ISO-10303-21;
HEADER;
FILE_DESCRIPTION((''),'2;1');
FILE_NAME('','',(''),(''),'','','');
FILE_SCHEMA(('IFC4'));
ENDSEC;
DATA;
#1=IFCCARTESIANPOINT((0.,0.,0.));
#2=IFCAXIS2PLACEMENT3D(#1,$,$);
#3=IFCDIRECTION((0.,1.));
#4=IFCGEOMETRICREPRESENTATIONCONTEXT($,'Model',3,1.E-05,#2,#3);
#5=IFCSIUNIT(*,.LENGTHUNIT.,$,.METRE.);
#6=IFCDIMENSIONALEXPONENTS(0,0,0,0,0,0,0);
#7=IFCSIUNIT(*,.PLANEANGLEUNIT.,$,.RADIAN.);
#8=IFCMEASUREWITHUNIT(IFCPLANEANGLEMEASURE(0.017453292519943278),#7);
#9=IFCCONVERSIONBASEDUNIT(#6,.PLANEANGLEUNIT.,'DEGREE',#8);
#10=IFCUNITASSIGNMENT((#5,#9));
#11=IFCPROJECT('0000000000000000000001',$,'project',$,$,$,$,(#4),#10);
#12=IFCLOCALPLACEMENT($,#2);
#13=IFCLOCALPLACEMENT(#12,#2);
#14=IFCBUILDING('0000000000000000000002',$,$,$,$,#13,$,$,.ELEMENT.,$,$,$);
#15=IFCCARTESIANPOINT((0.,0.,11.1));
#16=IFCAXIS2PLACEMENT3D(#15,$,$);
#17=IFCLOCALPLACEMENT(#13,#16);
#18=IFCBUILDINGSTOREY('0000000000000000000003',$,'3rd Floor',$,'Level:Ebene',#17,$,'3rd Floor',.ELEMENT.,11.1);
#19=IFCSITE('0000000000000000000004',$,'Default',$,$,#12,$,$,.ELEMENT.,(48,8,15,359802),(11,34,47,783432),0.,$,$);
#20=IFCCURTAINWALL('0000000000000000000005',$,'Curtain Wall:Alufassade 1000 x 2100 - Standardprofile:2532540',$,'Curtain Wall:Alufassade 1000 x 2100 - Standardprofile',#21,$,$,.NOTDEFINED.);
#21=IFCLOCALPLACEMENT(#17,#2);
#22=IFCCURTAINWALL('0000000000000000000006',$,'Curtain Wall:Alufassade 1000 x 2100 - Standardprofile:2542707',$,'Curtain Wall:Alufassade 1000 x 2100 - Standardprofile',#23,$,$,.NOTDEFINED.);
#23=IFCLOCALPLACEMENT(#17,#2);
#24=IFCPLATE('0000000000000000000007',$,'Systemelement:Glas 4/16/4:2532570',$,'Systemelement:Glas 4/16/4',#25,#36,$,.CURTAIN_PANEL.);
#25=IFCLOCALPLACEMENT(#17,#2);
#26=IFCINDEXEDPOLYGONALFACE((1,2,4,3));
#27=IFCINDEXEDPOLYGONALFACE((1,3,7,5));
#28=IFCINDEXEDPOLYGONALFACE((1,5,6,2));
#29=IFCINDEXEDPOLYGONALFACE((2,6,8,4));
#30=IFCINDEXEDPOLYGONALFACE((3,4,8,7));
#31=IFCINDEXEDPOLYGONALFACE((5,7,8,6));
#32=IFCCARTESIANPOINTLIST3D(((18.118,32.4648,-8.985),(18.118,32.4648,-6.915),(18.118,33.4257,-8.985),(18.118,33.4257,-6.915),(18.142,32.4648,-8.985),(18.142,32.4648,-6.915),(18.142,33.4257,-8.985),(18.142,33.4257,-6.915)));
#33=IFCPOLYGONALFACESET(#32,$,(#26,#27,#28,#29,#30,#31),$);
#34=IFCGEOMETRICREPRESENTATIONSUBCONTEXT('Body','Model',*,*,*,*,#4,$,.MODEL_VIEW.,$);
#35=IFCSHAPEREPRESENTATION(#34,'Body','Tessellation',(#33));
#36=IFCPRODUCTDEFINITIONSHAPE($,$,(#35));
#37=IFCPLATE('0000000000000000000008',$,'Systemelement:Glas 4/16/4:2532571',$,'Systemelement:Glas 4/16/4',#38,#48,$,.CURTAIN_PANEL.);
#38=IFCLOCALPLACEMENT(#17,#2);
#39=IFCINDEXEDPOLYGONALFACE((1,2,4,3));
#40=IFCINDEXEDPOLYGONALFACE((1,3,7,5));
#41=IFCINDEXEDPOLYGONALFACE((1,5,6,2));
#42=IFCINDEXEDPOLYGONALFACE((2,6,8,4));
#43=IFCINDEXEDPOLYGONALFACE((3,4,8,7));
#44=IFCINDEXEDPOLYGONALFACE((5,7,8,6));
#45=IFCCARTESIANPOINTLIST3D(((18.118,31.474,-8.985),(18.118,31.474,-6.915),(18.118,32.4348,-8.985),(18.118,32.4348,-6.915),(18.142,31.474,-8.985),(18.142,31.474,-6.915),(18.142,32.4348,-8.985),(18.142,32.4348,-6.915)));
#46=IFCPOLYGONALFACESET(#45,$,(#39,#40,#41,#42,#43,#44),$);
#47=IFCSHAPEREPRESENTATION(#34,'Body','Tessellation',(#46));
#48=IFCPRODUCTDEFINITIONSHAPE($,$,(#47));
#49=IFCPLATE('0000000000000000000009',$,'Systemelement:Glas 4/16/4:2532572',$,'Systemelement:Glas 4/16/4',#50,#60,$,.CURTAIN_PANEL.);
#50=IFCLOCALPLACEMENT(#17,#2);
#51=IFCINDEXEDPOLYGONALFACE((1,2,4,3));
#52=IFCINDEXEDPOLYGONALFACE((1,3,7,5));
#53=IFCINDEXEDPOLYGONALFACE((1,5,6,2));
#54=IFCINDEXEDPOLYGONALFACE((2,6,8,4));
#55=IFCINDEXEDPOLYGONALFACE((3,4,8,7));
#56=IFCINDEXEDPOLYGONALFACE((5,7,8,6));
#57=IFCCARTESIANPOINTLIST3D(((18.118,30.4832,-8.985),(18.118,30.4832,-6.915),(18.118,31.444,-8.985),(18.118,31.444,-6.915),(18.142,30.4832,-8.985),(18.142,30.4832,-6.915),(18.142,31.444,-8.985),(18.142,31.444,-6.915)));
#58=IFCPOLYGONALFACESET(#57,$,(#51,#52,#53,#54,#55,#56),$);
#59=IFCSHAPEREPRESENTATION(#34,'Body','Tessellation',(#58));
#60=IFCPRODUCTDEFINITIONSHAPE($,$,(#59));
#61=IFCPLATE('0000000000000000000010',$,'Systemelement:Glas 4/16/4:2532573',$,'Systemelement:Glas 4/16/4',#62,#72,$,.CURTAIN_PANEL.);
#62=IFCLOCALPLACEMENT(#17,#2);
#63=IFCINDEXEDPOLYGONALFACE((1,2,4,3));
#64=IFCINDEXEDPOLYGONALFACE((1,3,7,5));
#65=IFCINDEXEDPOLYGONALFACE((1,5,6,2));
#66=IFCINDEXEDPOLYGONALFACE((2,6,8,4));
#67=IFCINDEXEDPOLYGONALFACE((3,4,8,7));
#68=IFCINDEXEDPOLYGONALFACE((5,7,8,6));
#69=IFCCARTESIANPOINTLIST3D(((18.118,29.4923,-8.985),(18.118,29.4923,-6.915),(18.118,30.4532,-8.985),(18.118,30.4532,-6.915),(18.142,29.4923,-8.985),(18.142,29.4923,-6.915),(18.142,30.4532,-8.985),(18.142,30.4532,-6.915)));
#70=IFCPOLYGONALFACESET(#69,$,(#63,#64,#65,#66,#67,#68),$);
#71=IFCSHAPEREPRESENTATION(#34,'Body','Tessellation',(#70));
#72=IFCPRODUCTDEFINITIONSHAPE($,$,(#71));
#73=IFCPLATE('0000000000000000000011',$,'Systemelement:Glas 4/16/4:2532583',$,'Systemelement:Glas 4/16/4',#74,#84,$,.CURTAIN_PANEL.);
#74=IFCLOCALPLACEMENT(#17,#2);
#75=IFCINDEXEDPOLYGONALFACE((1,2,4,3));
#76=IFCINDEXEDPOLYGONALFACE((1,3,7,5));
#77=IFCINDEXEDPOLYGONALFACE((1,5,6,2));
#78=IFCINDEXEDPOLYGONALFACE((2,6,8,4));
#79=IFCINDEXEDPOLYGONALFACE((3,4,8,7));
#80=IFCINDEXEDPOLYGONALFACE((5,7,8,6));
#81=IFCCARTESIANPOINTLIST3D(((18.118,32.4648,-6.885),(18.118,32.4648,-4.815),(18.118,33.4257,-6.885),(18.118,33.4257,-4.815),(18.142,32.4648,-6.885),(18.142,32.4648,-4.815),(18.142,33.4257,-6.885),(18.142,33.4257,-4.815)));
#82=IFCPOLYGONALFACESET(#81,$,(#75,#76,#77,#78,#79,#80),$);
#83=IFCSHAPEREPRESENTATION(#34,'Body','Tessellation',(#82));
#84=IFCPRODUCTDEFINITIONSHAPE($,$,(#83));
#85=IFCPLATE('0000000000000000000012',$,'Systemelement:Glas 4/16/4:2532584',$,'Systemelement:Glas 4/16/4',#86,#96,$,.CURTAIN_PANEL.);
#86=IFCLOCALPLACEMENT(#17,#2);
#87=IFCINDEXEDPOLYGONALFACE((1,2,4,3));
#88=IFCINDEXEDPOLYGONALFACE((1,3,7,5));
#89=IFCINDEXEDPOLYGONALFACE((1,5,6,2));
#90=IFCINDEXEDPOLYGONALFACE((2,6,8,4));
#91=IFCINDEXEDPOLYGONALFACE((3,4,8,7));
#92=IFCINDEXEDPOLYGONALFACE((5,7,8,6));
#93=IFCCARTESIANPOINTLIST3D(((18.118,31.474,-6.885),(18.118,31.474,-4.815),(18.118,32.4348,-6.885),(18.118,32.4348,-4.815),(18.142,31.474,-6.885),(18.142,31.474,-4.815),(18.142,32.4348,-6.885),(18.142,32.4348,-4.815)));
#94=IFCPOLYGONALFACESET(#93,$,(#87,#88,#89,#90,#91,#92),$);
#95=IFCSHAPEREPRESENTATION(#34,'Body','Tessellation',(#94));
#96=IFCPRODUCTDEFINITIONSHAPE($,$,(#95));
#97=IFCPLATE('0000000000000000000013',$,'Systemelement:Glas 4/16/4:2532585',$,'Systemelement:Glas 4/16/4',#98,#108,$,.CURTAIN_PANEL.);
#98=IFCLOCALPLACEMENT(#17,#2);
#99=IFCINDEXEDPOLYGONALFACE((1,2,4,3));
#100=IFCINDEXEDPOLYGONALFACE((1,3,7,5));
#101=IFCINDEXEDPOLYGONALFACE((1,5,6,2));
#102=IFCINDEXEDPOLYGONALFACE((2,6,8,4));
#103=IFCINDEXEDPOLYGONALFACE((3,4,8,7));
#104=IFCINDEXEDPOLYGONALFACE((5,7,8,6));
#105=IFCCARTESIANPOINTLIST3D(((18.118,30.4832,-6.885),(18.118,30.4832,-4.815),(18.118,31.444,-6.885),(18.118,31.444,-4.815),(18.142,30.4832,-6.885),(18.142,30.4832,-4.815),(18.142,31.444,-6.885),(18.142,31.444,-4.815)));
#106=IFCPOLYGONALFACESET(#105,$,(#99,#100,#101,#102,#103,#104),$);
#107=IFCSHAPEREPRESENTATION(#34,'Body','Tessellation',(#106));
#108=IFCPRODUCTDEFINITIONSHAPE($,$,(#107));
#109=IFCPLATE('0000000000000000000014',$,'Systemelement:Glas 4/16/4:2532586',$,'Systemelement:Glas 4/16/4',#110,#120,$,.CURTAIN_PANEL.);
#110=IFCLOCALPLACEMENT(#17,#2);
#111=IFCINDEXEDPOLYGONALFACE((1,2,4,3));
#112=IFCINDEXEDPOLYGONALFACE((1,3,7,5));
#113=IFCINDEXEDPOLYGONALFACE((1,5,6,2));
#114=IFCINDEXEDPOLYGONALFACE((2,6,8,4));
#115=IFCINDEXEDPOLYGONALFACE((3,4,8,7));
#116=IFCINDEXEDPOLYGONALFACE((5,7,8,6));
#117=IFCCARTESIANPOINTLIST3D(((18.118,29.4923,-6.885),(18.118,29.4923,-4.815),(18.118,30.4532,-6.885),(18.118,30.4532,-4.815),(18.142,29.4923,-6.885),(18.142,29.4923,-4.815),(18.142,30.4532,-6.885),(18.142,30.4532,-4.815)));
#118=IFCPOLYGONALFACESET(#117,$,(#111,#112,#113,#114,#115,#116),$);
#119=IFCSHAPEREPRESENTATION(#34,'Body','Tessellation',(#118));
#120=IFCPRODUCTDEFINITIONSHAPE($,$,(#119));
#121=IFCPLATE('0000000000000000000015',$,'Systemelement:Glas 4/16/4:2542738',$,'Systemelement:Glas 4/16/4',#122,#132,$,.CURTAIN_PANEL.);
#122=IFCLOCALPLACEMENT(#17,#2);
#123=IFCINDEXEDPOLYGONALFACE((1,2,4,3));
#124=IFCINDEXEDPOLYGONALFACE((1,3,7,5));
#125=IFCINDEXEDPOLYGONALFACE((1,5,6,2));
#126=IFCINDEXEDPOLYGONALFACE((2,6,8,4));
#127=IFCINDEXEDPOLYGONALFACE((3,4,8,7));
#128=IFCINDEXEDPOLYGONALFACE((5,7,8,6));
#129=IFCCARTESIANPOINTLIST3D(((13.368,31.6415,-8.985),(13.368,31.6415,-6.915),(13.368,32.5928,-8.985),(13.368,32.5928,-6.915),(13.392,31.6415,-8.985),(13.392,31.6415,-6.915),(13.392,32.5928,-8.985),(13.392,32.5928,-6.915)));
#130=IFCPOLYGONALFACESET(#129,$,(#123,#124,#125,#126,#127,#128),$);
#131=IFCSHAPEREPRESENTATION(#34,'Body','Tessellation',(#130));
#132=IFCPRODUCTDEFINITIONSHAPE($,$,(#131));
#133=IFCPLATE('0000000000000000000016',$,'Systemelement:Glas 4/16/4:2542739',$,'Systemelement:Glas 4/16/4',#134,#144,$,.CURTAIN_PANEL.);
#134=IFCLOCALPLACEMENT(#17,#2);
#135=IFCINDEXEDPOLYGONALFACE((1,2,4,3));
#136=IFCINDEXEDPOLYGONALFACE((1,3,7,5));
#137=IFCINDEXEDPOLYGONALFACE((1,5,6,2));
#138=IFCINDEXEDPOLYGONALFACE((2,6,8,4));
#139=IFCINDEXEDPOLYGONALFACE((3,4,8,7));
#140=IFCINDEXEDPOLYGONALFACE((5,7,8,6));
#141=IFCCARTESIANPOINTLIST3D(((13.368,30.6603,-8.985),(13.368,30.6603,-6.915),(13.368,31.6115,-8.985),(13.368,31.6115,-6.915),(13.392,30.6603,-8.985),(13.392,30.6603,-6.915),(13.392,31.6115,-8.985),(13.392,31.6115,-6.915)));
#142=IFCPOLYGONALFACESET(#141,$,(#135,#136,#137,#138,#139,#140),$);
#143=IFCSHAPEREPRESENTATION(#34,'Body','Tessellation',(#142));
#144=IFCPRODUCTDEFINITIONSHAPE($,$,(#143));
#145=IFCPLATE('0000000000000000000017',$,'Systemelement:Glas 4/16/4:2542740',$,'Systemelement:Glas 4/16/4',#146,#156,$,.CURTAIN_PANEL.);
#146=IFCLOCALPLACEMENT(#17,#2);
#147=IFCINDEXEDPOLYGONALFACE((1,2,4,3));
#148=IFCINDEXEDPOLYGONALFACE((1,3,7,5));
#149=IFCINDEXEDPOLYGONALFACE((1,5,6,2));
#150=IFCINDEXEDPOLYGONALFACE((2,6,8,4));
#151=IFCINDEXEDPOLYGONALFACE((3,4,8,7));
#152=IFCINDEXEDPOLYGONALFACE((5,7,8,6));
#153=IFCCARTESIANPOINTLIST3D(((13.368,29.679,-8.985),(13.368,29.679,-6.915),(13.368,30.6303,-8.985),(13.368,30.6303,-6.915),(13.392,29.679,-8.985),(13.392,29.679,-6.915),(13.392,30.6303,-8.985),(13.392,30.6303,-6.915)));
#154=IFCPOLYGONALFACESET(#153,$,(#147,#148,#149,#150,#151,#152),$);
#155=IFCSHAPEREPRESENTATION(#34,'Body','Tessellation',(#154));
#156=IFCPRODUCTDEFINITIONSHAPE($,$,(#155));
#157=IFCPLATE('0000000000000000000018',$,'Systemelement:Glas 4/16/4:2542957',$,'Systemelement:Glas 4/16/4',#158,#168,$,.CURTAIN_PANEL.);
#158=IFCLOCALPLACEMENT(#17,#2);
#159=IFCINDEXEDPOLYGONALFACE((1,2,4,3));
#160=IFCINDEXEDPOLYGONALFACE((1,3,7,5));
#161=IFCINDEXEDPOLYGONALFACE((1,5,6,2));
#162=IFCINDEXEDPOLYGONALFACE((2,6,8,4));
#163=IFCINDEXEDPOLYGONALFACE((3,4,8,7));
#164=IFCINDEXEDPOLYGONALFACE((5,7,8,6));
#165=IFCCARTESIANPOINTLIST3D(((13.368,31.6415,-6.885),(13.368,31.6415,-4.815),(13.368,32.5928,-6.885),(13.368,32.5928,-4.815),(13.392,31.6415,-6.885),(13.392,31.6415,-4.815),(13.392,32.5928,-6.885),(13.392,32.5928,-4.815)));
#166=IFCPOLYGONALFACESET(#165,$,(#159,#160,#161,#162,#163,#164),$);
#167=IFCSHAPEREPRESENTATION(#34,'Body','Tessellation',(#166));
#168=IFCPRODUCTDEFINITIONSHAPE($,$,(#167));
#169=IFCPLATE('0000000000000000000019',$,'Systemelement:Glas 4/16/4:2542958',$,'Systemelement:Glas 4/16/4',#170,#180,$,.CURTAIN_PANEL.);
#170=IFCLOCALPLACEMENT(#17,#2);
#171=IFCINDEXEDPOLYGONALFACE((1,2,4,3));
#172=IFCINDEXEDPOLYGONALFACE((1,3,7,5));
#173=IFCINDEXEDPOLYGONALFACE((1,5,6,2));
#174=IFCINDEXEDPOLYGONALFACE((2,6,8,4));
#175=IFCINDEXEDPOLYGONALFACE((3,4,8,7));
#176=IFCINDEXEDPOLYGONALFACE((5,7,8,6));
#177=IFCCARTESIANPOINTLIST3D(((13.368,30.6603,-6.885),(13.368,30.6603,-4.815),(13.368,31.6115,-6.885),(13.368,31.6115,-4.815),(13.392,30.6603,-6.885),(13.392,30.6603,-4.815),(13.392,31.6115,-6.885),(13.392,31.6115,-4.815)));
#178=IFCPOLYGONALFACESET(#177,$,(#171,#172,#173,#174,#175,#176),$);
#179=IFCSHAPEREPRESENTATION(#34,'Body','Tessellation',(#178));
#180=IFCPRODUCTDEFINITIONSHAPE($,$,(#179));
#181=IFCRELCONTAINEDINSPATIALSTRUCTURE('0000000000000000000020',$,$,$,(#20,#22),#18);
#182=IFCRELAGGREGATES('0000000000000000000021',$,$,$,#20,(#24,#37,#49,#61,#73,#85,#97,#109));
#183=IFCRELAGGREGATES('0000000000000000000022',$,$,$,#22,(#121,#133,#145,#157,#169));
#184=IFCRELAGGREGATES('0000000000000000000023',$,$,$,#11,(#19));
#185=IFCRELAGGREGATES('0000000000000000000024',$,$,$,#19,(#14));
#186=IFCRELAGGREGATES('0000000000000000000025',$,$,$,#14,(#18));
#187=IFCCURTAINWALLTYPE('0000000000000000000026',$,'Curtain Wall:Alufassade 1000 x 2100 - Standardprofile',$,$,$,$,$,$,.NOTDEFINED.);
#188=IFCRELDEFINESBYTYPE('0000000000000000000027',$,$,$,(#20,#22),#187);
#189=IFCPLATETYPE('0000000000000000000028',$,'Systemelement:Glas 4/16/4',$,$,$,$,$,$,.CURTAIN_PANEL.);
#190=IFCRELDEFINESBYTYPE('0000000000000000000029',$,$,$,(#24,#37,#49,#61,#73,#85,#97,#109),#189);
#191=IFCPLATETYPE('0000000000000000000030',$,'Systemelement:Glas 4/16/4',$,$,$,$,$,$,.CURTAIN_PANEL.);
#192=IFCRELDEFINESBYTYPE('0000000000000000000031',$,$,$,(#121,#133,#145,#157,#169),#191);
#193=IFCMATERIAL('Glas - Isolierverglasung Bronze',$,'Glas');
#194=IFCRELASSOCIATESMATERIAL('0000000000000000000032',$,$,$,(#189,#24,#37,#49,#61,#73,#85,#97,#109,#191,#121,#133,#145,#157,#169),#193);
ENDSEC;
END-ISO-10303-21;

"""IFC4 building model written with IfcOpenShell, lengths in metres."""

from ifc_helpers import new_model, entity, si_unit, converted_unit, direction, frame, origin, place, context, subcontext, project, spatial, indexed_curve, outline, extrude, source, transform, mapped, material, type_object, type_shapes, element, aggregate, save


model = new_model("IFC4")

# Units and contexts
model_context = context("Model", 3, precision=1e-05, world=origin(), true_north=direction((0.0, 1.0)))
body_context = subcontext(model_context, "Body", "Model", "MODEL_VIEW")
ifc_project = project(units=[si_unit("LENGTHUNIT", "METRE"), converted_unit("PLANEANGLEUNIT", "DEGREE", entity("IfcPlaneAngleMeasure", 0.017453292519943278), si_unit("PLANEANGLEUNIT", "RADIAN"), dimensions=[0, 0, 0, 0, 0, 0, 0])], contexts=[model_context])

# Site, building, storey
site_placement = place(None, origin())
site = spatial("IfcSite", under=ifc_project, at=site_placement, Name="Default", CompositionType="ELEMENT", RefLatitude=(48, 8, 15, 359802), RefLongitude=(11, 34, 47, 783432), RefElevation=0.0)
building_placement = place(site_placement, origin())
building = spatial("IfcBuilding", under=site, at=building_placement, CompositionType="ELEMENT")
storey_placement = place(building_placement, frame((0.0, 0.0, 11.1)))
storey = spatial("IfcBuildingStorey", under=building, at=storey_placement, Name="3rd Floor", ObjectType="Level:Ebene", LongName="3rd Floor", CompositionType="ELEMENT", Elevation=11.1)

# Curtain walls
curtain_wall_type = type_object("IfcCurtainWallType", Name="Curtain Wall:Alufassade 1000 x 2100 - Standardprofile", PredefinedType="NOTDEFINED")
curtain_wall_1_placement = place(storey_placement, frame((0.0, 0.0, -11.1)))
curtain_wall_1 = element("IfcCurtainWall", 1, at=curtain_wall_1_placement, inside=storey, type_object=curtain_wall_type, Name="Curtain Wall:Alufassade 1000 x 2100 - Standardprofile:2532540", ObjectType="Curtain Wall:Alufassade 1000 x 2100 - Standardprofile", PredefinedType="NOTDEFINED")
curtain_wall_2_placement = place(storey_placement, frame((0.0, 0.0, -11.1)))
curtain_wall_2 = element("IfcCurtainWall", 2, at=curtain_wall_2_placement, inside=storey, type_object=curtain_wall_type, Name="Curtain Wall:Alufassade 1000 x 2100 - Standardprofile:2542707", ObjectType="Curtain Wall:Alufassade 1000 x 2100 - Standardprofile", PredefinedType="NOTDEFINED")

# Plates
ifc_material_1 = material(Name="Glas - Isolierverglasung Bronze", Category="Glas")
plate_type_1 = type_object("IfcPlateType", Name="Systemelement:Glas 4/16/4", PredefinedType="CURTAIN_PANEL", material=ifc_material_1)
shared_shape_1 = source(origin(), body_context, "Body", "SweptSolid", [
    extrude(outline(indexed_curve([(-0.012, -0.4804), (0.012, -0.4804), (0.012, 0.4804), (-0.012, 0.4804), (-0.012, -0.4804)], self_intersect=False)), frame((0.0, 0.0, 0.0), z_axis=(0.0, 0.0, 1.0), x_axis=(0.0, 1.0, 0.0)), (0.0, 0.0, 1.0), 2.07),
])
type_shapes(plate_type_1, [shared_shape_1])
plate_1_placement = place(curtain_wall_1_placement, frame((18.13, 32.9453, 2.115), z_axis=(0.0, 0.0, 1.0), x_axis=(0.0, -1.0, 0.0)))
plate_1 = element("IfcPlate", 3, at=plate_1_placement, type_object=plate_type_1, material=ifc_material_1, Name="Systemelement:Glas 4/16/4:2532570", ObjectType="Systemelement:Glas 4/16/4", PredefinedType="CURTAIN_PANEL", context=body_context, shape_type="MappedRepresentation", body=[
    mapped(shared_shape_1, transform((0.0, 0.0, 0.0), scale=1.0)),
])
plate_2_placement = place(curtain_wall_1_placement, frame((18.13, 31.9544, 2.115), z_axis=(0.0, 0.0, 1.0), x_axis=(0.0, -1.0, 0.0)))
plate_2 = element("IfcPlate", 4, at=plate_2_placement, type_object=plate_type_1, material=ifc_material_1, Name="Systemelement:Glas 4/16/4:2532571", ObjectType="Systemelement:Glas 4/16/4", PredefinedType="CURTAIN_PANEL", context=body_context, shape_type="MappedRepresentation", body=[
    mapped(shared_shape_1, transform((0.0, 0.0, 0.0), scale=1.0)),
])
plate_3_placement = place(curtain_wall_1_placement, frame((18.13, 30.9636, 2.115), z_axis=(0.0, 0.0, 1.0), x_axis=(0.0, -1.0, 0.0)))
plate_3 = element("IfcPlate", 5, at=plate_3_placement, type_object=plate_type_1, material=ifc_material_1, Name="Systemelement:Glas 4/16/4:2532572", ObjectType="Systemelement:Glas 4/16/4", PredefinedType="CURTAIN_PANEL", context=body_context, shape_type="MappedRepresentation", body=[
    mapped(shared_shape_1, transform((0.0, 0.0, 0.0), scale=1.0)),
])
plate_4_placement = place(curtain_wall_1_placement, frame((18.13, 29.9728, 2.115), z_axis=(0.0, 0.0, 1.0), x_axis=(0.0, -1.0, 0.0)))
plate_4 = element("IfcPlate", 6, at=plate_4_placement, type_object=plate_type_1, material=ifc_material_1, Name="Systemelement:Glas 4/16/4:2532573", ObjectType="Systemelement:Glas 4/16/4", PredefinedType="CURTAIN_PANEL", context=body_context, shape_type="MappedRepresentation", body=[
    mapped(shared_shape_1, transform((0.0, 0.0, 0.0), scale=1.0)),
])
plate_5_placement = place(curtain_wall_1_placement, frame((18.13, 32.9453, 4.215), z_axis=(0.0, 0.0, 1.0), x_axis=(0.0, -1.0, 0.0)))
plate_5 = element("IfcPlate", 7, at=plate_5_placement, type_object=plate_type_1, material=ifc_material_1, Name="Systemelement:Glas 4/16/4:2532583", ObjectType="Systemelement:Glas 4/16/4", PredefinedType="CURTAIN_PANEL", context=body_context, shape_type="MappedRepresentation", body=[
    mapped(shared_shape_1, transform((0.0, 0.0, 0.0), scale=1.0)),
])
plate_6_placement = place(curtain_wall_1_placement, frame((18.13, 31.9544, 4.215), z_axis=(0.0, 0.0, 1.0), x_axis=(0.0, -1.0, 0.0)))
plate_6 = element("IfcPlate", 8, at=plate_6_placement, type_object=plate_type_1, material=ifc_material_1, Name="Systemelement:Glas 4/16/4:2532584", ObjectType="Systemelement:Glas 4/16/4", PredefinedType="CURTAIN_PANEL", context=body_context, shape_type="MappedRepresentation", body=[
    mapped(shared_shape_1, transform((0.0, 0.0, 0.0), scale=1.0)),
])
plate_7_placement = place(curtain_wall_1_placement, frame((18.13, 30.9636, 4.215), z_axis=(0.0, 0.0, 1.0), x_axis=(0.0, -1.0, 0.0)))
plate_7 = element("IfcPlate", 9, at=plate_7_placement, type_object=plate_type_1, material=ifc_material_1, Name="Systemelement:Glas 4/16/4:2532585", ObjectType="Systemelement:Glas 4/16/4", PredefinedType="CURTAIN_PANEL", context=body_context, shape_type="MappedRepresentation", body=[
    mapped(shared_shape_1, transform((0.0, 0.0, 0.0), scale=1.0)),
])
plate_8_placement = place(curtain_wall_1_placement, frame((18.13, 29.9728, 4.215), z_axis=(0.0, 0.0, 1.0), x_axis=(0.0, -1.0, 0.0)))
plate_8 = element("IfcPlate", 10, at=plate_8_placement, type_object=plate_type_1, material=ifc_material_1, Name="Systemelement:Glas 4/16/4:2532586", ObjectType="Systemelement:Glas 4/16/4", PredefinedType="CURTAIN_PANEL", context=body_context, shape_type="MappedRepresentation", body=[
    mapped(shared_shape_1, transform((0.0, 0.0, 0.0), scale=1.0)),
])
aggregate(curtain_wall_1, [plate_1, plate_2, plate_3, plate_4, plate_5, plate_6, plate_7, plate_8])
plate_type_2 = type_object("IfcPlateType", Name="Systemelement:Glas 4/16/4", PredefinedType="CURTAIN_PANEL", material=ifc_material_1)
shared_shape_2 = source(origin(), body_context, "Body", "SweptSolid", [
    extrude(outline(indexed_curve([(-0.012, -0.4756), (0.012, -0.4756), (0.012, 0.4756), (-0.012, 0.4756), (-0.012, -0.4756)], self_intersect=False)), frame((0.0, 0.0, 0.0), z_axis=(0.0, 0.0, 1.0), x_axis=(0.0, 1.0, 0.0)), (0.0, 0.0, 1.0), 2.07),
])
type_shapes(plate_type_2, [shared_shape_2])
plate_9_placement = place(curtain_wall_2_placement, frame((13.38, 32.1171, 2.115), z_axis=(0.0, 0.0, 1.0), x_axis=(0.0, -1.0, 0.0)))
plate_9 = element("IfcPlate", 11, at=plate_9_placement, type_object=plate_type_2, material=ifc_material_1, Name="Systemelement:Glas 4/16/4:2542738", ObjectType="Systemelement:Glas 4/16/4", PredefinedType="CURTAIN_PANEL", context=body_context, shape_type="MappedRepresentation", body=[
    mapped(shared_shape_2, transform((0.0, 0.0, 0.0), scale=1.0)),
])
plate_10_placement = place(curtain_wall_2_placement, frame((13.38, 31.1359, 2.115), z_axis=(0.0, 0.0, 1.0), x_axis=(0.0, -1.0, 0.0)))
plate_10 = element("IfcPlate", 12, at=plate_10_placement, type_object=plate_type_2, material=ifc_material_1, Name="Systemelement:Glas 4/16/4:2542739", ObjectType="Systemelement:Glas 4/16/4", PredefinedType="CURTAIN_PANEL", context=body_context, shape_type="MappedRepresentation", body=[
    mapped(shared_shape_2, transform((0.0, 0.0, 0.0), scale=1.0)),
])
plate_11_placement = place(curtain_wall_2_placement, frame((13.38, 30.1546, 2.115), z_axis=(0.0, 0.0, 1.0), x_axis=(0.0, -1.0, 0.0)))
plate_11 = element("IfcPlate", 13, at=plate_11_placement, type_object=plate_type_2, material=ifc_material_1, Name="Systemelement:Glas 4/16/4:2542740", ObjectType="Systemelement:Glas 4/16/4", PredefinedType="CURTAIN_PANEL", context=body_context, shape_type="MappedRepresentation", body=[
    mapped(shared_shape_2, transform((0.0, 0.0, 0.0), scale=1.0)),
])
plate_12_placement = place(curtain_wall_2_placement, frame((13.38, 32.1171, 4.215), z_axis=(0.0, 0.0, 1.0), x_axis=(0.0, -1.0, 0.0)))
plate_12 = element("IfcPlate", 14, at=plate_12_placement, type_object=plate_type_2, material=ifc_material_1, Name="Systemelement:Glas 4/16/4:2542957", ObjectType="Systemelement:Glas 4/16/4", PredefinedType="CURTAIN_PANEL", context=body_context, shape_type="MappedRepresentation", body=[
    mapped(shared_shape_2, transform((0.0, 0.0, 0.0), scale=1.0)),
])
plate_13_placement = place(curtain_wall_2_placement, frame((13.38, 31.1359, 4.215), z_axis=(0.0, 0.0, 1.0), x_axis=(0.0, -1.0, 0.0)))
plate_13 = element("IfcPlate", 15, at=plate_13_placement, type_object=plate_type_2, material=ifc_material_1, Name="Systemelement:Glas 4/16/4:2542958", ObjectType="Systemelement:Glas 4/16/4", PredefinedType="CURTAIN_PANEL", context=body_context, shape_type="MappedRepresentation", body=[
    mapped(shared_shape_2, transform((0.0, 0.0, 0.0), scale=1.0)),
])
aggregate(curtain_wall_2, [plate_9, plate_10, plate_11, plate_12, plate_13])

save(model, "model.ifc")
